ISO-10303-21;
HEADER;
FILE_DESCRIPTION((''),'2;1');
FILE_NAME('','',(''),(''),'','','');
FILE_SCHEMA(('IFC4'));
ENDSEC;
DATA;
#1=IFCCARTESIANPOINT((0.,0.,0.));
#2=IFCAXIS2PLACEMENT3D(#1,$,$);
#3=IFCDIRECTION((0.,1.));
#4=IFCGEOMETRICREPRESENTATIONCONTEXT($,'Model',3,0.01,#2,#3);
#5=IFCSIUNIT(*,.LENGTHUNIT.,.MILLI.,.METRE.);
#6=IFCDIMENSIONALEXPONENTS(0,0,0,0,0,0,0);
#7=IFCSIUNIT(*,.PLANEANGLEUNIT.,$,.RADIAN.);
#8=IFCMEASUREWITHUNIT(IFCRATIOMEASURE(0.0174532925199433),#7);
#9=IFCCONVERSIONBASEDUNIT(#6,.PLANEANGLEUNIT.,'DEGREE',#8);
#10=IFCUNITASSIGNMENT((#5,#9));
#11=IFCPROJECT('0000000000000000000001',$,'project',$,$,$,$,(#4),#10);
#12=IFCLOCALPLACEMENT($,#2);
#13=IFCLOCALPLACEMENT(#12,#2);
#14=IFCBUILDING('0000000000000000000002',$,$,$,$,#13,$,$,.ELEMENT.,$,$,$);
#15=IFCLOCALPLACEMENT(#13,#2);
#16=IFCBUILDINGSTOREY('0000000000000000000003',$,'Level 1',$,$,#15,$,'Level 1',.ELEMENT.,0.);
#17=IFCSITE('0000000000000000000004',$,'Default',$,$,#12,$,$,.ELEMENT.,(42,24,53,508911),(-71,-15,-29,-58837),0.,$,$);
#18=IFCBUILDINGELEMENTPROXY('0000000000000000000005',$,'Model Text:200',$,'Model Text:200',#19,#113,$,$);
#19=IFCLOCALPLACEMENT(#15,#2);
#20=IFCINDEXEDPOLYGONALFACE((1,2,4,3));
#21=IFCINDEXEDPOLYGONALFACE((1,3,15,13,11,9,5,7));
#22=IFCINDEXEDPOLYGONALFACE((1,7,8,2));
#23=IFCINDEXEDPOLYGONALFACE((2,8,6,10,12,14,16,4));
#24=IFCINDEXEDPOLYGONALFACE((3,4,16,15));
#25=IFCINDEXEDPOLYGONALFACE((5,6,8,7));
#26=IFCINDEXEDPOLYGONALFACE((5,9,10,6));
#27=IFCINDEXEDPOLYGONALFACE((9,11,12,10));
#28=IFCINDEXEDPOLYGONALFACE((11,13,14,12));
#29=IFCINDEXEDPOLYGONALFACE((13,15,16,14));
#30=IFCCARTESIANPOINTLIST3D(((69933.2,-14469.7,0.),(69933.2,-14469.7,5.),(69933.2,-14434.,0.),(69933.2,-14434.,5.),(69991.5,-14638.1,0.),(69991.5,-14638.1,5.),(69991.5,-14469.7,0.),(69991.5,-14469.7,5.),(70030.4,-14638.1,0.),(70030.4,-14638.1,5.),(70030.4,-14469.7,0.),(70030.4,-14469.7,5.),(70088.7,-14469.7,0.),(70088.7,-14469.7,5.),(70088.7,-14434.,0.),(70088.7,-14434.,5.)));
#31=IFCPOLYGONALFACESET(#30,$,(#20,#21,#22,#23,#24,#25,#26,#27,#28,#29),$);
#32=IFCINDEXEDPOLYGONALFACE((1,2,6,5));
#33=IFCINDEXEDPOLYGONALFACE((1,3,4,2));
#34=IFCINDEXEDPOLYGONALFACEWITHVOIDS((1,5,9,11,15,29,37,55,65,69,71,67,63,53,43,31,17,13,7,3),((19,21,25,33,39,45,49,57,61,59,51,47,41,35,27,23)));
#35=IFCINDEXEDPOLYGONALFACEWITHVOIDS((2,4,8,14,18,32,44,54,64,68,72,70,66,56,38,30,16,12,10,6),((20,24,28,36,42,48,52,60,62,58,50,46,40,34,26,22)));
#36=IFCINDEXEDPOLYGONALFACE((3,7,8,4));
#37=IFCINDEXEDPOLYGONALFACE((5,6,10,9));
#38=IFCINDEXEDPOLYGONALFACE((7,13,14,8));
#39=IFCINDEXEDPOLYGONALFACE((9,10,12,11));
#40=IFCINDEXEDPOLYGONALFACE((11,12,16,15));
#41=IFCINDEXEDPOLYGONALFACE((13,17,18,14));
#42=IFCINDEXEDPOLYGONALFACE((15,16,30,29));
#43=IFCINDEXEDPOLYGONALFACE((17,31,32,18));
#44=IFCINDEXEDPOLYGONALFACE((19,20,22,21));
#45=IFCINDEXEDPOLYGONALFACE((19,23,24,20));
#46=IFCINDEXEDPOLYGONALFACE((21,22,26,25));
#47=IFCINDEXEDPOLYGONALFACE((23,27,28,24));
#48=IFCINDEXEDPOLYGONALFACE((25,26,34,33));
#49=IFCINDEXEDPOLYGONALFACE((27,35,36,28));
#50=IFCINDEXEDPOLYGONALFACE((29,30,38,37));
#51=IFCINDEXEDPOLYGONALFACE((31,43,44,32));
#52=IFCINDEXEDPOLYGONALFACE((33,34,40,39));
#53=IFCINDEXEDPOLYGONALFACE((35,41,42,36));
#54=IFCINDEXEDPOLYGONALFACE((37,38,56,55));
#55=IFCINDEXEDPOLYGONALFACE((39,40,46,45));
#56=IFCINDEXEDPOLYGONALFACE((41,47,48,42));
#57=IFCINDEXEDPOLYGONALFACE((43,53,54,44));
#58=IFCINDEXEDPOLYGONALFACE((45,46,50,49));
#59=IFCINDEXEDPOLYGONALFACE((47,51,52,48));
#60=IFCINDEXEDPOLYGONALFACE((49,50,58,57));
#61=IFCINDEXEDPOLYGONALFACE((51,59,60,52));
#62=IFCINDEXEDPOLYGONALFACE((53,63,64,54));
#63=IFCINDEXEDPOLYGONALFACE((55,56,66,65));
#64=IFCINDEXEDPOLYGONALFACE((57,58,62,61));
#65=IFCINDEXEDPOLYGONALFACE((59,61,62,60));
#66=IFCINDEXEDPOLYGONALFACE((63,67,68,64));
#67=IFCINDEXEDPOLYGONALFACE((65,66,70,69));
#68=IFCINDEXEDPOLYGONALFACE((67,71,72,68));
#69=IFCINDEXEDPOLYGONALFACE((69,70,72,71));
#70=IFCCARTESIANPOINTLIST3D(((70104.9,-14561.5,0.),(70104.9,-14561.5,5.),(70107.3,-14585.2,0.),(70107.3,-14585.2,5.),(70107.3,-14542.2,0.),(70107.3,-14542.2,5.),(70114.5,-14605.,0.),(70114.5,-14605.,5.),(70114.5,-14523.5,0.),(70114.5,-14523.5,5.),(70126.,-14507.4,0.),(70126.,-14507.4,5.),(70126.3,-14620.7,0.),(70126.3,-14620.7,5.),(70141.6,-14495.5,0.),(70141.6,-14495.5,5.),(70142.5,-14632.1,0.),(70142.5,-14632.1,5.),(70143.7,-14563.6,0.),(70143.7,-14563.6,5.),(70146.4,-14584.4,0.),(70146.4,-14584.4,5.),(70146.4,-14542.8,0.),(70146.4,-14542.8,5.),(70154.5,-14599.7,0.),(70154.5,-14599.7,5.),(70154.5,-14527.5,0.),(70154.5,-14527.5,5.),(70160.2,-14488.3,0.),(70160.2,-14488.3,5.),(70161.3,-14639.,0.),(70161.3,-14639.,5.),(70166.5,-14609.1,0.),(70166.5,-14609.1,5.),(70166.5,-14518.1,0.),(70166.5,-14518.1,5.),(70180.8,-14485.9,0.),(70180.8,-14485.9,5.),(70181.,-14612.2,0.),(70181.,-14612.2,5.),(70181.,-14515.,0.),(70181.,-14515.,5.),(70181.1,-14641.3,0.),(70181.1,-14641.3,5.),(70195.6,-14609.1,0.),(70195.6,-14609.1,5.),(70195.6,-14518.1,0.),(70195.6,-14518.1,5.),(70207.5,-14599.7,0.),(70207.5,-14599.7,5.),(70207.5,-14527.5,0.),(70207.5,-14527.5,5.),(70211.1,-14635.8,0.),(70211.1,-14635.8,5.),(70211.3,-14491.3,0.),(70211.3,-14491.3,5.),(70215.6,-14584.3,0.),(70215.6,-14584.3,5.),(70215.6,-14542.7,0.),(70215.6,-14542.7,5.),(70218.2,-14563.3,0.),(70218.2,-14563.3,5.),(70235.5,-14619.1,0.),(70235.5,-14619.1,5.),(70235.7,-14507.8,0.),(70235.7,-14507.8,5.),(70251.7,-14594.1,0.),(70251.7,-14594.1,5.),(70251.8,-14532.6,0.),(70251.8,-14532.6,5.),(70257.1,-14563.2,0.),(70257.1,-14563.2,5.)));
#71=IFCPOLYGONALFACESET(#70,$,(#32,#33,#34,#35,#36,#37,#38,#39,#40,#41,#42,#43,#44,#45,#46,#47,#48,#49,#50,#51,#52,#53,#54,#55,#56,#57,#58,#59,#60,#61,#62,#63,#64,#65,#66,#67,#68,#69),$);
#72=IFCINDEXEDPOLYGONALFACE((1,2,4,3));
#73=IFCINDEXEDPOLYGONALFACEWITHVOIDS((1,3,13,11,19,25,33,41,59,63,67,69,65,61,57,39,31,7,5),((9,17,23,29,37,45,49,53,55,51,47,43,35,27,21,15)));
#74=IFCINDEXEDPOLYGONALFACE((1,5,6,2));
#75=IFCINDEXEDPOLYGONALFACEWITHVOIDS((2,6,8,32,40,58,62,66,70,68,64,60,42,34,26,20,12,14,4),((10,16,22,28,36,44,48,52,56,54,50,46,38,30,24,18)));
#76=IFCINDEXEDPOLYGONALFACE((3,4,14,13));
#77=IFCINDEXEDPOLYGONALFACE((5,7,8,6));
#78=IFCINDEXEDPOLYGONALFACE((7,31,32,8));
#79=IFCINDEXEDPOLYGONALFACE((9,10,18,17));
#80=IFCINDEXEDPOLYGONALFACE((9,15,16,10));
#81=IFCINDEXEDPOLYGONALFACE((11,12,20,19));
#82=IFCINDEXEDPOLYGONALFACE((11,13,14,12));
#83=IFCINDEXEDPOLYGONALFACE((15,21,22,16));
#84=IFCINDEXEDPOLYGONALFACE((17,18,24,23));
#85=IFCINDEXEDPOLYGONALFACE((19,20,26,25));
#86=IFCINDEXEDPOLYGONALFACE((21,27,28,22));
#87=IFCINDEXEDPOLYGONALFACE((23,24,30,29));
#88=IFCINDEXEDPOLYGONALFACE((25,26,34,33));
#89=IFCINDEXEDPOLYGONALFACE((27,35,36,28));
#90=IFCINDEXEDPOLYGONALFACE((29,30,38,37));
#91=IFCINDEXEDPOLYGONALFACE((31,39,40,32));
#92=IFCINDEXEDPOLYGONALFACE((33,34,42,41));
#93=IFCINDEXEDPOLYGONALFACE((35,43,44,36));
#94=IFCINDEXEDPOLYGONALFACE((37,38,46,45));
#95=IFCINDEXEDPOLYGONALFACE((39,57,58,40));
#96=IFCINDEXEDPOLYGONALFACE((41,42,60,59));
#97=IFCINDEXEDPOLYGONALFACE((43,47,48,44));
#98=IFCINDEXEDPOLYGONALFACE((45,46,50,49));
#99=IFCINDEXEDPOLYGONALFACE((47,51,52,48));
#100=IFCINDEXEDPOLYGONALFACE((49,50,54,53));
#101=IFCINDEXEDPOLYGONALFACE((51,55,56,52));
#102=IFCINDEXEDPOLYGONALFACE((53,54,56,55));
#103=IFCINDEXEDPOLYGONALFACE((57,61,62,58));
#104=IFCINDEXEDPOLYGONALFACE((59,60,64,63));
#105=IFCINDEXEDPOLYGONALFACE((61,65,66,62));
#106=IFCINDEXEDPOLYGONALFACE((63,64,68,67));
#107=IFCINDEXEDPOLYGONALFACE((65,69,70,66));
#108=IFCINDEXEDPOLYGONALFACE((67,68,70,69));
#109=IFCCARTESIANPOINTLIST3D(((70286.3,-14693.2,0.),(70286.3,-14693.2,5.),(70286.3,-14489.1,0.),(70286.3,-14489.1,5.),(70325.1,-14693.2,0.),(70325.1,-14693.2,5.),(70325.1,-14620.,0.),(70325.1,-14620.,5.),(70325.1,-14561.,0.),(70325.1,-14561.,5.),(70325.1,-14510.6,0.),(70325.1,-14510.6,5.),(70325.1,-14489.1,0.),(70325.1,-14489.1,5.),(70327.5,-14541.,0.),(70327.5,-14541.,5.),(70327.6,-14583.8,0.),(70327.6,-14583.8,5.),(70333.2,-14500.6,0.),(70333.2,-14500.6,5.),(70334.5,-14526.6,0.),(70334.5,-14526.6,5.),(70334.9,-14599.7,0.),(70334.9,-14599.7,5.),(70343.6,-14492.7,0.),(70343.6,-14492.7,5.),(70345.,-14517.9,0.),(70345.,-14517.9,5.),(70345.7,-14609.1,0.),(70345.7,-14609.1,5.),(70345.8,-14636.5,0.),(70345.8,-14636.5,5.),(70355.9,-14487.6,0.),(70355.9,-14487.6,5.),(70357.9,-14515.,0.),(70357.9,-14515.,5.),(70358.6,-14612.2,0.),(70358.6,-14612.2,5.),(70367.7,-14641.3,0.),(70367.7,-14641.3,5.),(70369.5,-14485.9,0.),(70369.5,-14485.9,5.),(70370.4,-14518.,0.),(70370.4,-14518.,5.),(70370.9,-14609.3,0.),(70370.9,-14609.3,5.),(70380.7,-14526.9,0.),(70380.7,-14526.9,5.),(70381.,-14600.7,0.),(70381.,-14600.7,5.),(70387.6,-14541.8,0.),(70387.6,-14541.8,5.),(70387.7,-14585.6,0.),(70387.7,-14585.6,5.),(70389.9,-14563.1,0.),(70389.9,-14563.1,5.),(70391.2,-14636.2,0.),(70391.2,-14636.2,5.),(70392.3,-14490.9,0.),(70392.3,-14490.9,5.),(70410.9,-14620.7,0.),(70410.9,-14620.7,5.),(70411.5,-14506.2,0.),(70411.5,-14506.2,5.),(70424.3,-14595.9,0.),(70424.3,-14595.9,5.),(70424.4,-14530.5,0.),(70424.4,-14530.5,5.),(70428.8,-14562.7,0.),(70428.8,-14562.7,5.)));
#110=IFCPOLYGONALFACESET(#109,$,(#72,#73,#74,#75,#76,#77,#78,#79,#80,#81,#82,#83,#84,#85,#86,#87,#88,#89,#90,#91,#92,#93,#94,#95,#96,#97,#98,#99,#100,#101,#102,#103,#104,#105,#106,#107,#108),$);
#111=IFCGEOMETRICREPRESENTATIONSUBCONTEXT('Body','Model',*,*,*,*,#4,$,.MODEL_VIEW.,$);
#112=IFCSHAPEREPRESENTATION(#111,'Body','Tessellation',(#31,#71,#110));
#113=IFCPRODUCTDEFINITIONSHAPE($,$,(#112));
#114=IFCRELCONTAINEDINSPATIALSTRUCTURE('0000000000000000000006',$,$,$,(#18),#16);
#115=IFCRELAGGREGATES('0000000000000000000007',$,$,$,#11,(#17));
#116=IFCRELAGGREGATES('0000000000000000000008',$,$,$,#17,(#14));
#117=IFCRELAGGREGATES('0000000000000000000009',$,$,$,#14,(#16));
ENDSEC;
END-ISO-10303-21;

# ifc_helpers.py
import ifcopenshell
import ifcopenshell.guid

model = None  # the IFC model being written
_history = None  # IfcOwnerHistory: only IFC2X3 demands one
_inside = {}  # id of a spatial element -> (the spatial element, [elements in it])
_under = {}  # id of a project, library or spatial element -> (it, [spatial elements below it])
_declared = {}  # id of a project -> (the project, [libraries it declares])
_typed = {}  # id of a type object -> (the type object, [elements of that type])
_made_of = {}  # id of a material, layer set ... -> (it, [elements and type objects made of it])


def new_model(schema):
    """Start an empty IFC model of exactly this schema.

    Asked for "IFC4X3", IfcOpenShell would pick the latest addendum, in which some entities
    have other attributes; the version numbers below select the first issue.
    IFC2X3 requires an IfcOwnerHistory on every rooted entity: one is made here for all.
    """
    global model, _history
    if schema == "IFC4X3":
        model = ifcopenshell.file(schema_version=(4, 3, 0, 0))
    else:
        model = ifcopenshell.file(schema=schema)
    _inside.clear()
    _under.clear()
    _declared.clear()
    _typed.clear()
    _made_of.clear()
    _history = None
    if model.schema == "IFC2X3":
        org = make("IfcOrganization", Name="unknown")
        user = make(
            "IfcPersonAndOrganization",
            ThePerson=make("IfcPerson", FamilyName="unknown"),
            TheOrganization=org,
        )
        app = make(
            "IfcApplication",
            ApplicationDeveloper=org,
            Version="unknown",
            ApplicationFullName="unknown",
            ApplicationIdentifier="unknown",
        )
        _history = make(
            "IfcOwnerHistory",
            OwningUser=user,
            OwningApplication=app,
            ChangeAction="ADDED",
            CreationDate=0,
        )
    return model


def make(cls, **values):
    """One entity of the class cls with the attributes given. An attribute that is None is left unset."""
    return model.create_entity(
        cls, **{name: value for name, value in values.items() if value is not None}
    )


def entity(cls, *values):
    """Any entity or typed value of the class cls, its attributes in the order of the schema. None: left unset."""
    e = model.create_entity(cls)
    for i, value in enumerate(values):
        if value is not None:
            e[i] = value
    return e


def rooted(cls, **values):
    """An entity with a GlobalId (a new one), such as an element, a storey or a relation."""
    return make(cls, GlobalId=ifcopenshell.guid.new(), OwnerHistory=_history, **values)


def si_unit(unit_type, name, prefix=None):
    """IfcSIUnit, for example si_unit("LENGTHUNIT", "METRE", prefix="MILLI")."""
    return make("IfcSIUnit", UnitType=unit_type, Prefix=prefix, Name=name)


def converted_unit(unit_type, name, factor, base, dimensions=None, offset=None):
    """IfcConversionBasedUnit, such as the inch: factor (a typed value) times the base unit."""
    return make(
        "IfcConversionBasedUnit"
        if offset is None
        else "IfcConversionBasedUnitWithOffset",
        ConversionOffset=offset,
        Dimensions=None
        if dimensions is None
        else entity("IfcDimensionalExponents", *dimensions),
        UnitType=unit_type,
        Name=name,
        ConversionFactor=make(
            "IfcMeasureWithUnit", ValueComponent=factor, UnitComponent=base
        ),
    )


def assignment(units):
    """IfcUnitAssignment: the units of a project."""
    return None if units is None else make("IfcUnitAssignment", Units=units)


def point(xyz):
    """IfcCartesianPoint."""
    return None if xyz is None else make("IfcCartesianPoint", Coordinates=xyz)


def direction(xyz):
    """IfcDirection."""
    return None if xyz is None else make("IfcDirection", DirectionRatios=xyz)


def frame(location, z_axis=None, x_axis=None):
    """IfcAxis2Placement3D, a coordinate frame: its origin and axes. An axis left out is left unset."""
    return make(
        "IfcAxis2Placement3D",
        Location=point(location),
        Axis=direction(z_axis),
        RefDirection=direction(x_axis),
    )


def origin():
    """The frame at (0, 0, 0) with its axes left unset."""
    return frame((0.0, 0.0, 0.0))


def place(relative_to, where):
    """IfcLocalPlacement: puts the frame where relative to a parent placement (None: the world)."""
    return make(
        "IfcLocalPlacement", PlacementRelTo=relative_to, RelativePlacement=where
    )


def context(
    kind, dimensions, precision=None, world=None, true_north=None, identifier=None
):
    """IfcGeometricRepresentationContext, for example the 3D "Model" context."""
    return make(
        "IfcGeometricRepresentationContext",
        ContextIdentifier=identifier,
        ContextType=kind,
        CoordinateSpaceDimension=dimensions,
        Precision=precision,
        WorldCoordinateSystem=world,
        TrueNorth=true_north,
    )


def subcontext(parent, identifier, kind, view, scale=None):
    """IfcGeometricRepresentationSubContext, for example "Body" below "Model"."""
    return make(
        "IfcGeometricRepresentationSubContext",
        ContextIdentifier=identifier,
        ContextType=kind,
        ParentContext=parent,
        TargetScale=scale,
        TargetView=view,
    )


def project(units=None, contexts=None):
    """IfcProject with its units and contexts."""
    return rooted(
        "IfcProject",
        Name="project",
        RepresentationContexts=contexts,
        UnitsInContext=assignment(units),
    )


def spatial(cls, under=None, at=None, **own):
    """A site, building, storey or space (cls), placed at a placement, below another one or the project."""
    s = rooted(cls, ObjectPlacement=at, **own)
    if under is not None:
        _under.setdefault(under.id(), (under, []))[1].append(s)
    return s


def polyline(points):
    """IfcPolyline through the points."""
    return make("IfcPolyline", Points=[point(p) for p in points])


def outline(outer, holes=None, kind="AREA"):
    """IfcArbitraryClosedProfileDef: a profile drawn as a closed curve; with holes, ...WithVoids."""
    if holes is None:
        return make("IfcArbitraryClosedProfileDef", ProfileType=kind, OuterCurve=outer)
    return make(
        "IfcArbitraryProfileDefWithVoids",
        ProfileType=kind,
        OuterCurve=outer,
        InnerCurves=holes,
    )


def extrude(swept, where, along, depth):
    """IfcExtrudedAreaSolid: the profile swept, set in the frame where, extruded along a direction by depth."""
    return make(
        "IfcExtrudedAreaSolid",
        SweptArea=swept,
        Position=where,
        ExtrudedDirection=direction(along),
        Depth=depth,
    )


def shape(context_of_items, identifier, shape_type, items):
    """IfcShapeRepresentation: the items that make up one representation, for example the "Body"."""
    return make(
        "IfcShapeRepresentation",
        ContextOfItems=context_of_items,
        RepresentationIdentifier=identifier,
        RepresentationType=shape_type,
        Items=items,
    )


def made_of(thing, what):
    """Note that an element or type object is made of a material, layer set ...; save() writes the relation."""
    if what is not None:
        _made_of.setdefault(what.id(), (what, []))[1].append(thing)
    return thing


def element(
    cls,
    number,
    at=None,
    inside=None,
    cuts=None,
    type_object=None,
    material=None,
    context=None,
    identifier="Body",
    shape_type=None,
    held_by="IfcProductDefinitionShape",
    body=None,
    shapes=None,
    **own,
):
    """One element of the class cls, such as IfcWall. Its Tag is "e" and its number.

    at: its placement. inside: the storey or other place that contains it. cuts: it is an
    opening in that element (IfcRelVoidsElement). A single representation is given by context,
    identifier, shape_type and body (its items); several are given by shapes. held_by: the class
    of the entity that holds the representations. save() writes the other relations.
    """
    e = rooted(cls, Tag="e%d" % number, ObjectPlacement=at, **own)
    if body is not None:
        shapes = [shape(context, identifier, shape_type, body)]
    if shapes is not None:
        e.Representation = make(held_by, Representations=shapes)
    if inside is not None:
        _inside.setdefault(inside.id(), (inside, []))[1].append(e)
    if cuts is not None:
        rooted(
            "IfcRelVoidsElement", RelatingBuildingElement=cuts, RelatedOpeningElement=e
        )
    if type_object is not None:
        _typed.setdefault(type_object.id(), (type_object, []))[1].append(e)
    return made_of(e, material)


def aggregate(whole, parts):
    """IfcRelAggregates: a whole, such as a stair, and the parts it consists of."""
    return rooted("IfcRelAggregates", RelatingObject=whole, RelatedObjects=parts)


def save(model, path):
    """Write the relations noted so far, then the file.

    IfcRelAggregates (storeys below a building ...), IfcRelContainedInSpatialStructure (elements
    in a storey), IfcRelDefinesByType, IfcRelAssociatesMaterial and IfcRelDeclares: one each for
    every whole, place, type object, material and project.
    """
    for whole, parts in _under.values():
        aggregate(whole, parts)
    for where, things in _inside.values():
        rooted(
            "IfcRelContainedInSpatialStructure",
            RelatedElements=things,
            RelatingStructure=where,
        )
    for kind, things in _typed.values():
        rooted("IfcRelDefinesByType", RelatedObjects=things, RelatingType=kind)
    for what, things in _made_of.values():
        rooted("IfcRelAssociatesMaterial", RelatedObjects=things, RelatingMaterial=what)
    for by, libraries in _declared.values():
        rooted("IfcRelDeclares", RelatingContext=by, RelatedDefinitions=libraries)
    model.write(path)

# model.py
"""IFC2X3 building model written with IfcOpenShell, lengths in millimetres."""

from ifc_helpers import new_model, entity, si_unit, converted_unit, direction, frame, origin, place, context, subcontext, project, spatial, polyline, outline, extrude, element, save


model = new_model("IFC2X3")

# Units and contexts
model_context = context("Model", 3, precision=0.01, world=origin(), true_north=direction((0.0, 1.0)))
body_context = subcontext(model_context, "Body", "Model", "MODEL_VIEW")
ifc_project = project(units=[si_unit("LENGTHUNIT", "METRE", prefix="MILLI"), converted_unit("PLANEANGLEUNIT", "DEGREE", entity("IfcRatioMeasure", 0.0174532925199433), si_unit("PLANEANGLEUNIT", "RADIAN"), dimensions=[0, 0, 0, 0, 0, 0, 0])], contexts=[model_context])

# Site, building, storey
site_placement = place(None, origin())
site = spatial("IfcSite", under=ifc_project, at=site_placement, Name="Default", CompositionType="ELEMENT", RefLatitude=(42, 24, 53, 508911), RefLongitude=(-71, -15, -29, -58837), RefElevation=0.0)
building_placement = place(site_placement, origin())
building = spatial("IfcBuilding", under=site, at=building_placement, CompositionType="ELEMENT")
storey_placement = place(building_placement, origin())
storey = spatial("IfcBuildingStorey", under=building, at=storey_placement, Name="Level 1", LongName="Level 1", CompositionType="ELEMENT", Elevation=0.0)

# Building element proxy
proxy_1_placement = place(storey_placement, origin())
element("IfcBuildingElementProxy", 1, at=proxy_1_placement, inside=storey, Name="Model Text:200", ObjectType="Model Text:200", context=body_context, shape_type="SweptSolid", body=[
    extrude(outline(polyline([(-19.4, -135.2), (19.4, -135.2), (19.4, 33.2), (77.7, 33.2), (77.7, 68.8), (-77.7, 68.8), (-77.7, 33.2), (-19.4, 33.2), (-19.4, -135.2)])), frame((70010.9, -14502.9, 0.0)), (0.0, 0.0, 1.0), 5.0),
    extrude(outline(polyline([(-8.8, -65.7), (15.1, -65.7), (35.5, -60.5), (52.3, -50.4), (65.3, -35.4), (74.1, -17.3), (78.4, 2.1), (75.9, 32.5), (61.8, 58.5), (38.4, 77.1), (8.3, 85.6), (-22.7, 83.3), (-49.0, 69.9), (-67.8, 47.3), (-76.3, 17.5), (-76.0, -3.3), (-70.7, -22.5), (-60.5, -39.2), (-45.5, -52.3), (-27.7, -61.4), (-8.8, -65.7)]), holes=[polyline([(-2.7, -27.2), (-23.1, -22.5), (-37.5, -12.9), (-45.7, 0.0), (-47.3, 14.8), (-42.7, 28.9), (-32.2, 39.9), (-16.3, 46.3), (4.5, 46.9), (25.1, 42.1), (39.6, 32.6), (47.7, 19.7), (49.4, 5.0), (44.8, -9.2), (34.2, -20.2), (18.2, -26.7), (-2.7, -27.2)])]), frame((70171.1, -14563.6, 0.0), z_axis=(0.0, 0.0, 1.0), x_axis=(0.100608, -0.994926, 0.0)), (0.0, 0.0, 1.0), 5.0),
    extrude(outline(polyline([(-73.1, -75.4), (130.9, -75.4), (130.9, -36.6), (57.8, -36.6), (74.3, -15.9), (79.1, 6.0), (73.9, 29.5), (58.4, 49.2), (33.6, 62.6), (0.5, 67.1), (-31.8, 62.8), (-56.1, 49.8), (-71.3, 30.7), (-76.4, 7.8), (-74.7, -5.8), (-69.6, -18.1), (-61.7, -28.5), (-51.7, -36.6), (-73.1, -36.6), (-73.1, -75.4)]), holes=[polyline([(-1.2, -36.6), (-21.2, -34.2), (-35.6, -27.2), (-44.3, -16.7), (-47.2, -3.8), (-44.3, 8.7), (-35.4, 19.0), (-20.4, 25.9), (0.8, 28.2), (23.3, 26.0), (38.5, 19.3), (47.1, 9.2), (49.9, -3.1), (46.8, -16.0), (37.4, -26.8), (21.5, -34.1), (-1.2, -36.6)])]), frame((70361.7, -14562.3, 0.0), z_axis=(0.0, 0.0, 1.0), x_axis=(0.0, -1.0, 0.0)), (0.0, 0.0, 1.0), 5.0),
])

save(model, "model.ifc")
